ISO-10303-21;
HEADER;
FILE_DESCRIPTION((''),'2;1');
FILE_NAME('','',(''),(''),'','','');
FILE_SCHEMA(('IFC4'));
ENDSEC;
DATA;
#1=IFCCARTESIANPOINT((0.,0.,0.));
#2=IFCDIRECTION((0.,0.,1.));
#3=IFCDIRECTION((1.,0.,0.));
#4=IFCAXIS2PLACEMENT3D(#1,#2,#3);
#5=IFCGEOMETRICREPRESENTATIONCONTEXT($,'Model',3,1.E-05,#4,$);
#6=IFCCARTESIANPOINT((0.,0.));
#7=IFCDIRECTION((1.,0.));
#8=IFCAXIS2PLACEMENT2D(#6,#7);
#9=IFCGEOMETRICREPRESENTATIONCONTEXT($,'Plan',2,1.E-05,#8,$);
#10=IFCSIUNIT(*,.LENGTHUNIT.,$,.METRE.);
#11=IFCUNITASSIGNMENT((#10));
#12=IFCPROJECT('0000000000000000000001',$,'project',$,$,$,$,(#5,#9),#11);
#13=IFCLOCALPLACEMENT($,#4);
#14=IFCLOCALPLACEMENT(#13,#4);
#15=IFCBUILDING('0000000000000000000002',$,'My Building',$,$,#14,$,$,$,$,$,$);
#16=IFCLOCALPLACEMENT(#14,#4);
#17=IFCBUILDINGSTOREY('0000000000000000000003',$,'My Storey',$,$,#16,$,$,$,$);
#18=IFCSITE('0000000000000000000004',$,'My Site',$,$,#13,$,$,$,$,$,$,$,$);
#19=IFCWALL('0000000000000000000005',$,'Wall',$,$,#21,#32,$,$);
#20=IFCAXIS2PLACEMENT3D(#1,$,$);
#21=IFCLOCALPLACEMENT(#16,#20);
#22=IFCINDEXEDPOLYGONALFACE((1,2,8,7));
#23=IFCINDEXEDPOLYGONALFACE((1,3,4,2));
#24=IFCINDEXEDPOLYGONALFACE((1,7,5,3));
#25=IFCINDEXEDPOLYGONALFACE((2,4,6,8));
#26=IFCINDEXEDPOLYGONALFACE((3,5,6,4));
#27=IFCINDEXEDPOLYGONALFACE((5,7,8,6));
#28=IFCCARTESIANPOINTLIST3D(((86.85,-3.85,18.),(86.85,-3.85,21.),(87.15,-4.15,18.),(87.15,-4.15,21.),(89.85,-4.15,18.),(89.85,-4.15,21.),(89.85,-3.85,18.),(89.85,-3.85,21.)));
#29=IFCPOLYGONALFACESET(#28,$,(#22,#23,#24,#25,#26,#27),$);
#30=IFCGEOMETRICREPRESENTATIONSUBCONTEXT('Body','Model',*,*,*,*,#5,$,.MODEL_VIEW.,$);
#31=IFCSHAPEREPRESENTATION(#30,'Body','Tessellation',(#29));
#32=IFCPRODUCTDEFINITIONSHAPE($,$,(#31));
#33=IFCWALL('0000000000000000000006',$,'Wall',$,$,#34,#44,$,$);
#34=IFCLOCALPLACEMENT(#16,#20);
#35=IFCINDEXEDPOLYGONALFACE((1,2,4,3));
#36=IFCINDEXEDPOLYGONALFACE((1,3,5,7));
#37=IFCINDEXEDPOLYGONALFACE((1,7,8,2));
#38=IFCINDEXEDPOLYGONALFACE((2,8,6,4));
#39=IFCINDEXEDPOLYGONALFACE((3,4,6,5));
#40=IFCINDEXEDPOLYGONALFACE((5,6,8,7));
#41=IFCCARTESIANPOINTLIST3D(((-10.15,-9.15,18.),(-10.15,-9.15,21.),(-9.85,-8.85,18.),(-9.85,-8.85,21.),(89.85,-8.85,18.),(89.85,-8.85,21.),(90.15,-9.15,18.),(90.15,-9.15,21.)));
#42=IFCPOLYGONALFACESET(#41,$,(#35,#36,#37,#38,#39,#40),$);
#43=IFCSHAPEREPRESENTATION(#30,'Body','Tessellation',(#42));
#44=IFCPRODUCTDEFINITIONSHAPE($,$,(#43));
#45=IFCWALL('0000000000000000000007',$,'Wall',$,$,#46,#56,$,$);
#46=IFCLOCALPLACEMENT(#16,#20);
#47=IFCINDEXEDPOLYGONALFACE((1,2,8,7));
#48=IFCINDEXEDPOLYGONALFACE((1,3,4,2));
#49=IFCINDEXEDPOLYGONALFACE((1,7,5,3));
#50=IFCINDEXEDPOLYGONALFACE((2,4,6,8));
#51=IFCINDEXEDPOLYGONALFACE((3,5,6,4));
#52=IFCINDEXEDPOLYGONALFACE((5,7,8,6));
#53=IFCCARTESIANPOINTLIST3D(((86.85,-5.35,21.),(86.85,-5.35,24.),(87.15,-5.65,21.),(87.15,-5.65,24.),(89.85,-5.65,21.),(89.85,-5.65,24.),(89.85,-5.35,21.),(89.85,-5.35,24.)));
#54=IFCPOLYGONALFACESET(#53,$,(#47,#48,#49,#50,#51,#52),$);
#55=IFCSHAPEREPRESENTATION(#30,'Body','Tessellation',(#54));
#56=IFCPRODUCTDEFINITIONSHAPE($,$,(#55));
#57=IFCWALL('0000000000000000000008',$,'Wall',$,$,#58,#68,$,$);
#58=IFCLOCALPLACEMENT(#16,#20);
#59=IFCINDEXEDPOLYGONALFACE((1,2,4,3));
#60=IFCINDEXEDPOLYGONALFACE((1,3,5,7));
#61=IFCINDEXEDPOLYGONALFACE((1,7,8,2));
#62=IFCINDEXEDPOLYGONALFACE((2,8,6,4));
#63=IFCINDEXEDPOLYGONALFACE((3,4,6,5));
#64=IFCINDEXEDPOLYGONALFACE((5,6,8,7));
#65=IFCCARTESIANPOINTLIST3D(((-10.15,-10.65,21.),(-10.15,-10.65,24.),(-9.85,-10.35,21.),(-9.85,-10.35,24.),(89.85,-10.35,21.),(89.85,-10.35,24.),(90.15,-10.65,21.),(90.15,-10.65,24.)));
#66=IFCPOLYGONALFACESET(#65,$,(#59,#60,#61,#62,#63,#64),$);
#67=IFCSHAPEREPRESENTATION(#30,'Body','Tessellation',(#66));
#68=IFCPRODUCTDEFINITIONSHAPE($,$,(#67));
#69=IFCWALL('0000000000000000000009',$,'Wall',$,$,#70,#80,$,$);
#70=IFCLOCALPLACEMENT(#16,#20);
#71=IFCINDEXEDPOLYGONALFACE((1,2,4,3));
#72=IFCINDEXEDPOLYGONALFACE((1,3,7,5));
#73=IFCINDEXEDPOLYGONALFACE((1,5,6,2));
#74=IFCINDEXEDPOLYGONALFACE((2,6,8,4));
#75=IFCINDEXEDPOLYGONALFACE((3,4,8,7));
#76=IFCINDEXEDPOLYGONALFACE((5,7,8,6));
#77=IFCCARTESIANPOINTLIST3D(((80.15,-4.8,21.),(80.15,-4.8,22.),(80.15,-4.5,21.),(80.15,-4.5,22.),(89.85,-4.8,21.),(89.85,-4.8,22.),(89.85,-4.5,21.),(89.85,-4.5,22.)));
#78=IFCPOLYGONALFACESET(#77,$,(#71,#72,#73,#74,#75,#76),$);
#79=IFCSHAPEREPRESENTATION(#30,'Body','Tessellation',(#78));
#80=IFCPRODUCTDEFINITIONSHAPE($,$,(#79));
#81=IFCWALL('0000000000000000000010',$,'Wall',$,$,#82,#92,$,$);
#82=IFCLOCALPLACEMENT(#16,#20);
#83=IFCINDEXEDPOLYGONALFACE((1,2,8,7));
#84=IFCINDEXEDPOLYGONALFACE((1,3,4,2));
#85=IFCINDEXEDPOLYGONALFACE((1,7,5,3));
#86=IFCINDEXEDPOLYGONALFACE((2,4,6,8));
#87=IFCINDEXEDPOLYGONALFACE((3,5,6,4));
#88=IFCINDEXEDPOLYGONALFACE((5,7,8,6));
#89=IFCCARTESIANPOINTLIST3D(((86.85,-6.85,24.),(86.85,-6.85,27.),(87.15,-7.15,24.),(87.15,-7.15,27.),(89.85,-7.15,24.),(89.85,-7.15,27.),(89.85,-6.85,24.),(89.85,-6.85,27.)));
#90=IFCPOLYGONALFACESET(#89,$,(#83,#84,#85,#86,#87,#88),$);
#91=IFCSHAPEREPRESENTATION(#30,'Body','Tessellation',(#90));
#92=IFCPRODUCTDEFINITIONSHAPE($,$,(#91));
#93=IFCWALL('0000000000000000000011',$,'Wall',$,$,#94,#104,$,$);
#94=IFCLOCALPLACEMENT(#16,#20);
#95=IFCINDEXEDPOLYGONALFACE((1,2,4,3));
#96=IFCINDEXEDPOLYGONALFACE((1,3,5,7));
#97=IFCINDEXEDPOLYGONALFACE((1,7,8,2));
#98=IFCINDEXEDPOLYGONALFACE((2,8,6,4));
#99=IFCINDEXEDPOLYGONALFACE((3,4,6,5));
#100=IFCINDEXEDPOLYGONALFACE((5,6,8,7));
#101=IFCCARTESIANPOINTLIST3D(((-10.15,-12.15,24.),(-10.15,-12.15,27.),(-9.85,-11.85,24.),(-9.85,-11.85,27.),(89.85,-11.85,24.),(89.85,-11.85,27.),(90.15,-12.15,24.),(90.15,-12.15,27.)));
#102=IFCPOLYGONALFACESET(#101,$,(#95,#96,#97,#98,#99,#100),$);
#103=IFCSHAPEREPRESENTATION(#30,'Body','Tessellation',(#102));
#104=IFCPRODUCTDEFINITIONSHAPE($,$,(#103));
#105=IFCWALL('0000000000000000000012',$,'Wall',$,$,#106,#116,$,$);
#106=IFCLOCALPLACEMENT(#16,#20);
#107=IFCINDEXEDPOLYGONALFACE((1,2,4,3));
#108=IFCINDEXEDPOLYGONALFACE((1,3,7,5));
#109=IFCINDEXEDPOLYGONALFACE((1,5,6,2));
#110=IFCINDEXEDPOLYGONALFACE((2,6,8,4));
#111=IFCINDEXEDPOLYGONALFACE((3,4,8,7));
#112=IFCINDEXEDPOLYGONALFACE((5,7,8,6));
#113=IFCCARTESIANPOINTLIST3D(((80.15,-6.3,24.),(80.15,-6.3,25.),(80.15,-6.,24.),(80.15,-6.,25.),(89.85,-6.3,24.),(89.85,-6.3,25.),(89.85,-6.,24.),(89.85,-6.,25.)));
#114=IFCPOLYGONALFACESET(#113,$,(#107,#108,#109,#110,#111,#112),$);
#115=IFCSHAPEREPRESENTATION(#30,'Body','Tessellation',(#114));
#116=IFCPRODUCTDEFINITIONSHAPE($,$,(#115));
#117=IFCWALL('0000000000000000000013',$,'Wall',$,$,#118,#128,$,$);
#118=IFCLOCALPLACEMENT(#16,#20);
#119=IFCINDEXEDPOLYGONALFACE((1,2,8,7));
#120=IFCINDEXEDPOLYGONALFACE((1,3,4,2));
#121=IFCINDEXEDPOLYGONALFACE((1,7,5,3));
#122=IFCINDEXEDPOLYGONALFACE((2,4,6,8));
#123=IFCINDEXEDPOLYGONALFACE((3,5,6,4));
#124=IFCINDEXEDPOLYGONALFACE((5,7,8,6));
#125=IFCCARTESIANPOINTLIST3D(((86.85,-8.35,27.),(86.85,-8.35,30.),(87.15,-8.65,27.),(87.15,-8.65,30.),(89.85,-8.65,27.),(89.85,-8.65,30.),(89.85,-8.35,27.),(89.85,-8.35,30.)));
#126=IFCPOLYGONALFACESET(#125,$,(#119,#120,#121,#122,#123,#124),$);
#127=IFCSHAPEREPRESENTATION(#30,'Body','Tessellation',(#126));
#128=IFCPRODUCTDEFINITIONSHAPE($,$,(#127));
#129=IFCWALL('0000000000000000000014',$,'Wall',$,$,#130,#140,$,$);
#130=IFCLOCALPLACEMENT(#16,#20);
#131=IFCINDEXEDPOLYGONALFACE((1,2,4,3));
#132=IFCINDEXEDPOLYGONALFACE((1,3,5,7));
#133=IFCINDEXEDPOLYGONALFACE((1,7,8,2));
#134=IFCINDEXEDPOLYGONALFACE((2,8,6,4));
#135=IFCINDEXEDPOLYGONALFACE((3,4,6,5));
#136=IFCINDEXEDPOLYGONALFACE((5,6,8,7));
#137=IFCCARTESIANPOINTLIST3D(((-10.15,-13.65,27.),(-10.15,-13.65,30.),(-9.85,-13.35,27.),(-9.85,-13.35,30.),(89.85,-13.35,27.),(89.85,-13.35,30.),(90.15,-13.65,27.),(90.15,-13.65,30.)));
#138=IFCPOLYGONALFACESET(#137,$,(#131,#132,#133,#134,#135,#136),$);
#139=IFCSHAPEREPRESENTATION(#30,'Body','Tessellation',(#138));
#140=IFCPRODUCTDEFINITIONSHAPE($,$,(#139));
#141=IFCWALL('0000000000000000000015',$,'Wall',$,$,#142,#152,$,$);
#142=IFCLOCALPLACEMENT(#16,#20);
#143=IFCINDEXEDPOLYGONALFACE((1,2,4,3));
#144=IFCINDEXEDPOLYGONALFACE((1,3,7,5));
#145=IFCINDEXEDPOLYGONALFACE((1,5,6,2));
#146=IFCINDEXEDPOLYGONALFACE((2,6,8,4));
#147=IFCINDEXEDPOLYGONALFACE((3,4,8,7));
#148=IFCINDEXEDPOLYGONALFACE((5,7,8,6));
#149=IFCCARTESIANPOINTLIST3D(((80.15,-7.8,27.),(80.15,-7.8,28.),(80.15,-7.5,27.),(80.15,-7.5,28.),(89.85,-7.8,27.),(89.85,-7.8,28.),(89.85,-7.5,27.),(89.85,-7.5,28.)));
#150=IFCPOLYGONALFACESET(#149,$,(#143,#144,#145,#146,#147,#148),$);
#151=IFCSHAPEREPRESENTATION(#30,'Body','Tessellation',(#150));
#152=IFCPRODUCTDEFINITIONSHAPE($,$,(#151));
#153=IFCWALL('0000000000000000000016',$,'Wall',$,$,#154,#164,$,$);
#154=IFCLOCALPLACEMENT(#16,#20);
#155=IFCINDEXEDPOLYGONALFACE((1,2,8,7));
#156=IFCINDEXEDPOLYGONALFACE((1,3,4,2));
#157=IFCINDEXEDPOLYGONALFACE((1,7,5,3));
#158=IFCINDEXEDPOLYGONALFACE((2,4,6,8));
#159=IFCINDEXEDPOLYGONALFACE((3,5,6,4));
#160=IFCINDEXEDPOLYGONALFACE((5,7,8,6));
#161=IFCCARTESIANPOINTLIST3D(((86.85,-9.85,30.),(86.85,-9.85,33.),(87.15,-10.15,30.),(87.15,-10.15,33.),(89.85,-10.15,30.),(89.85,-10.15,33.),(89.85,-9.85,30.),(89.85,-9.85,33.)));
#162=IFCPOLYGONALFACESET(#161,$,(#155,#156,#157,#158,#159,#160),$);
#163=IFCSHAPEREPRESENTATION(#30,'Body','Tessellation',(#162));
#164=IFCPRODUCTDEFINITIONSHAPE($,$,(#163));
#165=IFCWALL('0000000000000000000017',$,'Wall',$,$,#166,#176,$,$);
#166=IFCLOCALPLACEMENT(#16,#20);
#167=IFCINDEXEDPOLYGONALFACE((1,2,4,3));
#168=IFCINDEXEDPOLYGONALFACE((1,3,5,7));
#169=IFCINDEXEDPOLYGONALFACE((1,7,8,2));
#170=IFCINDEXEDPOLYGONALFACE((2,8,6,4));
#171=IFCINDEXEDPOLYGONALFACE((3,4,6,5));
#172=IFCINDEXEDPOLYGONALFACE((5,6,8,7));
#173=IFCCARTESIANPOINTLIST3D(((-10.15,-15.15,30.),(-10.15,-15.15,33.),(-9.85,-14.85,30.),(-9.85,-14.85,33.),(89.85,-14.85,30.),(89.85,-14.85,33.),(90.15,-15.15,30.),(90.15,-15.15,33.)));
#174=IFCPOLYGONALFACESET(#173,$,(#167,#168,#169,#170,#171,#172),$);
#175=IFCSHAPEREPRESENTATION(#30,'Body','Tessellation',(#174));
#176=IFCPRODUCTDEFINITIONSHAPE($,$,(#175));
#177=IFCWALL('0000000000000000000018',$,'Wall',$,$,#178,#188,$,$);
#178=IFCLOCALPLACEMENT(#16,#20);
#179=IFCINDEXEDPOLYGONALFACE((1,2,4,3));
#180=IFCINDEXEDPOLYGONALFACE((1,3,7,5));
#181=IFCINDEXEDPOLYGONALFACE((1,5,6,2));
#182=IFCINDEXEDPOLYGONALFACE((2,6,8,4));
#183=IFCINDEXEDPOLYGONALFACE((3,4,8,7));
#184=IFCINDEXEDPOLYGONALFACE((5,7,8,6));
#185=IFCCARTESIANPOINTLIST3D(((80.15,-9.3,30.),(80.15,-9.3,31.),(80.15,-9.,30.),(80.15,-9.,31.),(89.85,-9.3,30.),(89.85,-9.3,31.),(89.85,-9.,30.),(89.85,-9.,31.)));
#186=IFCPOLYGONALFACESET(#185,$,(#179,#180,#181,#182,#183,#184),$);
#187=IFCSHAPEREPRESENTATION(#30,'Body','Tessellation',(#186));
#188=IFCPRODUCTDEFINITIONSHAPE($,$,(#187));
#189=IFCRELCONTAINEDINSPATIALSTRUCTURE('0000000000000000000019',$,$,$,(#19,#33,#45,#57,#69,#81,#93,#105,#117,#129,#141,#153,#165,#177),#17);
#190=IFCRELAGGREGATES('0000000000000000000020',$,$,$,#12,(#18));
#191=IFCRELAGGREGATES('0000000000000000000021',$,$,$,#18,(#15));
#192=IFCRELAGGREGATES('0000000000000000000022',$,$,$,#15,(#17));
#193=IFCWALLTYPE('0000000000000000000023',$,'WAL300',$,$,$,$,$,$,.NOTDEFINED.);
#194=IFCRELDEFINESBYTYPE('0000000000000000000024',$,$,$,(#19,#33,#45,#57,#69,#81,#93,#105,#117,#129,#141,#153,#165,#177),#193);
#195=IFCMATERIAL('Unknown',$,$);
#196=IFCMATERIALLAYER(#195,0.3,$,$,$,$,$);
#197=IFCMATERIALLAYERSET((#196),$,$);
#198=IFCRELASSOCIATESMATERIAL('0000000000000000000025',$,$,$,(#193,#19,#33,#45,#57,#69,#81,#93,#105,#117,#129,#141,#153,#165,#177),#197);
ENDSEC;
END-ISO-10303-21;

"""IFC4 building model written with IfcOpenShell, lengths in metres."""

from ifc_helpers import new_model, si_unit, frame, origin_with_axes, origin_2d_with_axis, place, context, subcontext, project, spatial, line, indexed_curve, outline, extrude, material, layer, layer_set, layer_usage, type_object, element, save


model = new_model("IFC4")

# Units and contexts
model_context = context("Model", 3, precision=1e-05, world=origin_with_axes())
plan_context = context("Plan", 2, precision=1e-05, world=origin_2d_with_axis())
body_context = subcontext(model_context, "Body", "Model", "MODEL_VIEW")
ifc_project = project(units=[si_unit("LENGTHUNIT", "METRE")], contexts=[model_context, plan_context])

# Site, building, storey
site_placement = place(None, origin_with_axes())
site = spatial("IfcSite", under=ifc_project, at=site_placement, Name="My Site")
building_placement = place(site_placement, origin_with_axes())
building = spatial("IfcBuilding", under=site, at=building_placement, Name="My Building")
storey_placement = place(building_placement, origin_with_axes())
storey = spatial("IfcBuildingStorey", under=building, at=storey_placement, Name="My Storey")

# Walls
ifc_material = material(Name="Unknown")
ifc_layer = layer(ifc_material, 0.3)
ifc_layer_set = layer_set([ifc_layer])
wall_type = type_object("IfcWallType", Name="WAL300", PredefinedType="NOTDEFINED", material=ifc_layer_set)
ifc_layer_usage_1 = layer_usage(ifc_layer_set, "AXIS2", "POSITIVE", -0.15)
wall_1_placement = place(storey_placement, frame((87.0, -4.0, 18.0), z_axis=(0.0, 0.0, 1.0), x_axis=(1.0, 0.0, 0.0)))
element("IfcWall", 1, at=wall_1_placement, inside=storey, type_object=wall_type, material=ifc_layer_usage_1, Name="Wall", context=body_context, shape_type="SweptSolid", body=[
    extrude(outline(indexed_curve([(0.15, -0.15), (-0.15, 0.15), (2.85, 0.15), (2.85, -0.15)], segments=[line(1, 2, 3, 4, 1)])), origin_with_axes(), (0.0, 0.0, 1.0), 3.0),
])
ifc_layer_usage_2 = layer_usage(ifc_layer_set, "AXIS2", "POSITIVE", -0.15)
wall_2_placement = place(storey_placement, frame((90.0, -9.0, 18.0), z_axis=(0.0, 0.0, 1.0), x_axis=(-1.0, 0.0, 0.0)))
element("IfcWall", 2, at=wall_2_placement, inside=storey, type_object=wall_type, material=ifc_layer_usage_2, Name="Wall", context=body_context, shape_type="SweptSolid", body=[
    extrude(outline(indexed_curve([(0.15, -0.15), (-0.15, 0.15), (100.15, 0.15), (99.85, -0.15)], segments=[line(1, 2, 3, 4, 1)])), origin_with_axes(), (0.0, 0.0, 1.0), 3.0),
])
ifc_layer_usage_3 = layer_usage(ifc_layer_set, "AXIS2", "POSITIVE", -0.15)
wall_3_placement = place(storey_placement, frame((87.0, -5.5, 21.0), z_axis=(0.0, 0.0, 1.0), x_axis=(1.0, 0.0, 0.0)))
element("IfcWall", 3, at=wall_3_placement, inside=storey, type_object=wall_type, material=ifc_layer_usage_3, Name="Wall", context=body_context, shape_type="SweptSolid", body=[
    extrude(outline(indexed_curve([(0.15, -0.15), (-0.15, 0.15), (2.85, 0.15), (2.85, -0.15)], segments=[line(1, 2, 3, 4, 1)])), origin_with_axes(), (0.0, 0.0, 1.0), 3.0),
])
ifc_layer_usage_4 = layer_usage(ifc_layer_set, "AXIS2", "POSITIVE", -0.15)
wall_4_placement = place(storey_placement, frame((90.0, -10.5, 21.0), z_axis=(0.0, 0.0, 1.0), x_axis=(-1.0, 0.0, 0.0)))
element("IfcWall", 4, at=wall_4_placement, inside=storey, type_object=wall_type, material=ifc_layer_usage_4, Name="Wall", context=body_context, shape_type="SweptSolid", body=[
    extrude(outline(indexed_curve([(0.15, -0.15), (-0.15, 0.15), (100.15, 0.15), (99.85, -0.15)], segments=[line(1, 2, 3, 4, 1)])), origin_with_axes(), (0.0, 0.0, 1.0), 3.0),
])
ifc_layer_usage_5 = layer_usage(ifc_layer_set, "AXIS2", "POSITIVE", -0.3)
wall_5_placement = place(storey_placement, frame((80.15, -4.5, 21.0), z_axis=(0.0, 0.0, 1.0), x_axis=(1.0, 0.0, 0.0)))
element("IfcWall", 5, at=wall_5_placement, inside=storey, type_object=wall_type, material=ifc_layer_usage_5, Name="Wall", context=body_context, shape_type="SweptSolid", body=[
    extrude(outline(indexed_curve([(0.0, -0.3), (0.0, 0.0), (9.7, 0.0), (9.7, -0.3)], segments=[line(1, 2, 3, 4, 1)])), origin_with_axes(), (0.0, 0.0, 1.0), 1.0),
])
ifc_layer_usage_6 = layer_usage(ifc_layer_set, "AXIS2", "POSITIVE", -0.15)
wall_6_placement = place(storey_placement, frame((87.0, -7.0, 24.0), z_axis=(0.0, 0.0, 1.0), x_axis=(1.0, 0.0, 0.0)))
element("IfcWall", 6, at=wall_6_placement, inside=storey, type_object=wall_type, material=ifc_layer_usage_6, Name="Wall", context=body_context, shape_type="SweptSolid", body=[
    extrude(outline(indexed_curve([(0.15, -0.15), (-0.15, 0.15), (2.85, 0.15), (2.85, -0.15)], segments=[line(1, 2, 3, 4, 1)])), origin_with_axes(), (0.0, 0.0, 1.0), 3.0),
])
ifc_layer_usage_7 = layer_usage(ifc_layer_set, "AXIS2", "POSITIVE", -0.15)
wall_7_placement = place(storey_placement, frame((90.0, -12.0, 24.0), z_axis=(0.0, 0.0, 1.0), x_axis=(-1.0, 0.0, 0.0)))
element("IfcWall", 7, at=wall_7_placement, inside=storey, type_object=wall_type, material=ifc_layer_usage_7, Name="Wall", context=body_context, shape_type="SweptSolid", body=[
    extrude(outline(indexed_curve([(0.15, -0.15), (-0.15, 0.15), (100.15, 0.15), (99.85, -0.15)], segments=[line(1, 2, 3, 4, 1)])), origin_with_axes(), (0.0, 0.0, 1.0), 3.0),
])
ifc_layer_usage_8 = layer_usage(ifc_layer_set, "AXIS2", "POSITIVE", -0.3)
wall_8_placement = place(storey_placement, frame((80.15, -6.0, 24.0), z_axis=(0.0, 0.0, 1.0), x_axis=(1.0, 0.0, 0.0)))
element("IfcWall", 8, at=wall_8_placement, inside=storey, type_object=wall_type, material=ifc_layer_usage_8, Name="Wall", context=body_context, shape_type="SweptSolid", body=[
    extrude(outline(indexed_curve([(0.0, -0.3), (0.0, 0.0), (9.7, 0.0), (9.7, -0.3)], segments=[line(1, 2, 3, 4, 1)])), origin_with_axes(), (0.0, 0.0, 1.0), 1.0),
])
ifc_layer_usage_9 = layer_usage(ifc_layer_set, "AXIS2", "POSITIVE", -0.15)
wall_9_placement = place(storey_placement, frame((87.0, -8.5, 27.0), z_axis=(0.0, 0.0, 1.0), x_axis=(1.0, 0.0, 0.0)))
element("IfcWall", 9, at=wall_9_placement, inside=storey, type_object=wall_type, material=ifc_layer_usage_9, Name="Wall", context=body_context, shape_type="SweptSolid", body=[
    extrude(outline(indexed_curve([(0.15, -0.15), (-0.15, 0.15), (2.85, 0.15), (2.85, -0.15)], segments=[line(1, 2, 3, 4, 1)])), origin_with_axes(), (0.0, 0.0, 1.0), 3.0),
])
ifc_layer_usage_10 = layer_usage(ifc_layer_set, "AXIS2", "POSITIVE", -0.15)
wall_10_placement = place(storey_placement, frame((90.0, -13.5, 27.0), z_axis=(0.0, 0.0, 1.0), x_axis=(-1.0, 0.0, 0.0)))
element("IfcWall", 10, at=wall_10_placement, inside=storey, type_object=wall_type, material=ifc_layer_usage_10, Name="Wall", context=body_context, shape_type="SweptSolid", body=[
    extrude(outline(indexed_curve([(0.15, -0.15), (-0.15, 0.15), (100.15, 0.15), (99.85, -0.15)], segments=[line(1, 2, 3, 4, 1)])), origin_with_axes(), (0.0, 0.0, 1.0), 3.0),
])
ifc_layer_usage_11 = layer_usage(ifc_layer_set, "AXIS2", "POSITIVE", -0.3)
wall_11_placement = place(storey_placement, frame((80.15, -7.5, 27.0), z_axis=(0.0, 0.0, 1.0), x_axis=(1.0, 0.0, 0.0)))
element("IfcWall", 11, at=wall_11_placement, inside=storey, type_object=wall_type, material=ifc_layer_usage_11, Name="Wall", context=body_context, shape_type="SweptSolid", body=[
    extrude(outline(indexed_curve([(0.0, -0.3), (0.0, 0.0), (9.7, 0.0), (9.7, -0.3)], segments=[line(1, 2, 3, 4, 1)])), origin_with_axes(), (0.0, 0.0, 1.0), 1.0),
])
ifc_layer_usage_12 = layer_usage(ifc_layer_set, "AXIS2", "POSITIVE", -0.15)
wall_12_placement = place(storey_placement, frame((87.0, -10.0, 30.0), z_axis=(0.0, 0.0, 1.0), x_axis=(1.0, 0.0, 0.0)))
element("IfcWall", 12, at=wall_12_placement, inside=storey, type_object=wall_type, material=ifc_layer_usage_12, Name="Wall", context=body_context, shape_type="SweptSolid", body=[
    extrude(outline(indexed_curve([(0.15, -0.15), (-0.15, 0.15), (2.85, 0.15), (2.85, -0.15)], segments=[line(1, 2, 3, 4, 1)])), origin_with_axes(), (0.0, 0.0, 1.0), 3.0),
])
ifc_layer_usage_13 = layer_usage(ifc_layer_set, "AXIS2", "POSITIVE", -0.15)
wall_13_placement = place(storey_placement, frame((90.0, -15.0, 30.0), z_axis=(0.0, 0.0, 1.0), x_axis=(-1.0, 0.0, 0.0)))
element("IfcWall", 13, at=wall_13_placement, inside=storey, type_object=wall_type, material=ifc_layer_usage_13, Name="Wall", context=body_context, shape_type="SweptSolid", body=[
    extrude(outline(indexed_curve([(0.15, -0.15), (-0.15, 0.15), (100.15, 0.15), (99.85, -0.15)], segments=[line(1, 2, 3, 4, 1)])), origin_with_axes(), (0.0, 0.0, 1.0), 3.0),
])
ifc_layer_usage_14 = layer_usage(ifc_layer_set, "AXIS2", "POSITIVE", -0.3)
wall_14_placement = place(storey_placement, frame((80.15, -9.0, 30.0), z_axis=(0.0, 0.0, 1.0), x_axis=(1.0, 0.0, 0.0)))
element("IfcWall", 14, at=wall_14_placement, inside=storey, type_object=wall_type, material=ifc_layer_usage_14, Name="Wall", context=body_context, shape_type="SweptSolid", body=[
    extrude(outline(indexed_curve([(0.0, -0.3), (0.0, 0.0), (9.7, 0.0), (9.7, -0.3)], segments=[line(1, 2, 3, 4, 1)])), origin_with_axes(), (0.0, 0.0, 1.0), 1.0),
])

save(model, "model.ifc")
